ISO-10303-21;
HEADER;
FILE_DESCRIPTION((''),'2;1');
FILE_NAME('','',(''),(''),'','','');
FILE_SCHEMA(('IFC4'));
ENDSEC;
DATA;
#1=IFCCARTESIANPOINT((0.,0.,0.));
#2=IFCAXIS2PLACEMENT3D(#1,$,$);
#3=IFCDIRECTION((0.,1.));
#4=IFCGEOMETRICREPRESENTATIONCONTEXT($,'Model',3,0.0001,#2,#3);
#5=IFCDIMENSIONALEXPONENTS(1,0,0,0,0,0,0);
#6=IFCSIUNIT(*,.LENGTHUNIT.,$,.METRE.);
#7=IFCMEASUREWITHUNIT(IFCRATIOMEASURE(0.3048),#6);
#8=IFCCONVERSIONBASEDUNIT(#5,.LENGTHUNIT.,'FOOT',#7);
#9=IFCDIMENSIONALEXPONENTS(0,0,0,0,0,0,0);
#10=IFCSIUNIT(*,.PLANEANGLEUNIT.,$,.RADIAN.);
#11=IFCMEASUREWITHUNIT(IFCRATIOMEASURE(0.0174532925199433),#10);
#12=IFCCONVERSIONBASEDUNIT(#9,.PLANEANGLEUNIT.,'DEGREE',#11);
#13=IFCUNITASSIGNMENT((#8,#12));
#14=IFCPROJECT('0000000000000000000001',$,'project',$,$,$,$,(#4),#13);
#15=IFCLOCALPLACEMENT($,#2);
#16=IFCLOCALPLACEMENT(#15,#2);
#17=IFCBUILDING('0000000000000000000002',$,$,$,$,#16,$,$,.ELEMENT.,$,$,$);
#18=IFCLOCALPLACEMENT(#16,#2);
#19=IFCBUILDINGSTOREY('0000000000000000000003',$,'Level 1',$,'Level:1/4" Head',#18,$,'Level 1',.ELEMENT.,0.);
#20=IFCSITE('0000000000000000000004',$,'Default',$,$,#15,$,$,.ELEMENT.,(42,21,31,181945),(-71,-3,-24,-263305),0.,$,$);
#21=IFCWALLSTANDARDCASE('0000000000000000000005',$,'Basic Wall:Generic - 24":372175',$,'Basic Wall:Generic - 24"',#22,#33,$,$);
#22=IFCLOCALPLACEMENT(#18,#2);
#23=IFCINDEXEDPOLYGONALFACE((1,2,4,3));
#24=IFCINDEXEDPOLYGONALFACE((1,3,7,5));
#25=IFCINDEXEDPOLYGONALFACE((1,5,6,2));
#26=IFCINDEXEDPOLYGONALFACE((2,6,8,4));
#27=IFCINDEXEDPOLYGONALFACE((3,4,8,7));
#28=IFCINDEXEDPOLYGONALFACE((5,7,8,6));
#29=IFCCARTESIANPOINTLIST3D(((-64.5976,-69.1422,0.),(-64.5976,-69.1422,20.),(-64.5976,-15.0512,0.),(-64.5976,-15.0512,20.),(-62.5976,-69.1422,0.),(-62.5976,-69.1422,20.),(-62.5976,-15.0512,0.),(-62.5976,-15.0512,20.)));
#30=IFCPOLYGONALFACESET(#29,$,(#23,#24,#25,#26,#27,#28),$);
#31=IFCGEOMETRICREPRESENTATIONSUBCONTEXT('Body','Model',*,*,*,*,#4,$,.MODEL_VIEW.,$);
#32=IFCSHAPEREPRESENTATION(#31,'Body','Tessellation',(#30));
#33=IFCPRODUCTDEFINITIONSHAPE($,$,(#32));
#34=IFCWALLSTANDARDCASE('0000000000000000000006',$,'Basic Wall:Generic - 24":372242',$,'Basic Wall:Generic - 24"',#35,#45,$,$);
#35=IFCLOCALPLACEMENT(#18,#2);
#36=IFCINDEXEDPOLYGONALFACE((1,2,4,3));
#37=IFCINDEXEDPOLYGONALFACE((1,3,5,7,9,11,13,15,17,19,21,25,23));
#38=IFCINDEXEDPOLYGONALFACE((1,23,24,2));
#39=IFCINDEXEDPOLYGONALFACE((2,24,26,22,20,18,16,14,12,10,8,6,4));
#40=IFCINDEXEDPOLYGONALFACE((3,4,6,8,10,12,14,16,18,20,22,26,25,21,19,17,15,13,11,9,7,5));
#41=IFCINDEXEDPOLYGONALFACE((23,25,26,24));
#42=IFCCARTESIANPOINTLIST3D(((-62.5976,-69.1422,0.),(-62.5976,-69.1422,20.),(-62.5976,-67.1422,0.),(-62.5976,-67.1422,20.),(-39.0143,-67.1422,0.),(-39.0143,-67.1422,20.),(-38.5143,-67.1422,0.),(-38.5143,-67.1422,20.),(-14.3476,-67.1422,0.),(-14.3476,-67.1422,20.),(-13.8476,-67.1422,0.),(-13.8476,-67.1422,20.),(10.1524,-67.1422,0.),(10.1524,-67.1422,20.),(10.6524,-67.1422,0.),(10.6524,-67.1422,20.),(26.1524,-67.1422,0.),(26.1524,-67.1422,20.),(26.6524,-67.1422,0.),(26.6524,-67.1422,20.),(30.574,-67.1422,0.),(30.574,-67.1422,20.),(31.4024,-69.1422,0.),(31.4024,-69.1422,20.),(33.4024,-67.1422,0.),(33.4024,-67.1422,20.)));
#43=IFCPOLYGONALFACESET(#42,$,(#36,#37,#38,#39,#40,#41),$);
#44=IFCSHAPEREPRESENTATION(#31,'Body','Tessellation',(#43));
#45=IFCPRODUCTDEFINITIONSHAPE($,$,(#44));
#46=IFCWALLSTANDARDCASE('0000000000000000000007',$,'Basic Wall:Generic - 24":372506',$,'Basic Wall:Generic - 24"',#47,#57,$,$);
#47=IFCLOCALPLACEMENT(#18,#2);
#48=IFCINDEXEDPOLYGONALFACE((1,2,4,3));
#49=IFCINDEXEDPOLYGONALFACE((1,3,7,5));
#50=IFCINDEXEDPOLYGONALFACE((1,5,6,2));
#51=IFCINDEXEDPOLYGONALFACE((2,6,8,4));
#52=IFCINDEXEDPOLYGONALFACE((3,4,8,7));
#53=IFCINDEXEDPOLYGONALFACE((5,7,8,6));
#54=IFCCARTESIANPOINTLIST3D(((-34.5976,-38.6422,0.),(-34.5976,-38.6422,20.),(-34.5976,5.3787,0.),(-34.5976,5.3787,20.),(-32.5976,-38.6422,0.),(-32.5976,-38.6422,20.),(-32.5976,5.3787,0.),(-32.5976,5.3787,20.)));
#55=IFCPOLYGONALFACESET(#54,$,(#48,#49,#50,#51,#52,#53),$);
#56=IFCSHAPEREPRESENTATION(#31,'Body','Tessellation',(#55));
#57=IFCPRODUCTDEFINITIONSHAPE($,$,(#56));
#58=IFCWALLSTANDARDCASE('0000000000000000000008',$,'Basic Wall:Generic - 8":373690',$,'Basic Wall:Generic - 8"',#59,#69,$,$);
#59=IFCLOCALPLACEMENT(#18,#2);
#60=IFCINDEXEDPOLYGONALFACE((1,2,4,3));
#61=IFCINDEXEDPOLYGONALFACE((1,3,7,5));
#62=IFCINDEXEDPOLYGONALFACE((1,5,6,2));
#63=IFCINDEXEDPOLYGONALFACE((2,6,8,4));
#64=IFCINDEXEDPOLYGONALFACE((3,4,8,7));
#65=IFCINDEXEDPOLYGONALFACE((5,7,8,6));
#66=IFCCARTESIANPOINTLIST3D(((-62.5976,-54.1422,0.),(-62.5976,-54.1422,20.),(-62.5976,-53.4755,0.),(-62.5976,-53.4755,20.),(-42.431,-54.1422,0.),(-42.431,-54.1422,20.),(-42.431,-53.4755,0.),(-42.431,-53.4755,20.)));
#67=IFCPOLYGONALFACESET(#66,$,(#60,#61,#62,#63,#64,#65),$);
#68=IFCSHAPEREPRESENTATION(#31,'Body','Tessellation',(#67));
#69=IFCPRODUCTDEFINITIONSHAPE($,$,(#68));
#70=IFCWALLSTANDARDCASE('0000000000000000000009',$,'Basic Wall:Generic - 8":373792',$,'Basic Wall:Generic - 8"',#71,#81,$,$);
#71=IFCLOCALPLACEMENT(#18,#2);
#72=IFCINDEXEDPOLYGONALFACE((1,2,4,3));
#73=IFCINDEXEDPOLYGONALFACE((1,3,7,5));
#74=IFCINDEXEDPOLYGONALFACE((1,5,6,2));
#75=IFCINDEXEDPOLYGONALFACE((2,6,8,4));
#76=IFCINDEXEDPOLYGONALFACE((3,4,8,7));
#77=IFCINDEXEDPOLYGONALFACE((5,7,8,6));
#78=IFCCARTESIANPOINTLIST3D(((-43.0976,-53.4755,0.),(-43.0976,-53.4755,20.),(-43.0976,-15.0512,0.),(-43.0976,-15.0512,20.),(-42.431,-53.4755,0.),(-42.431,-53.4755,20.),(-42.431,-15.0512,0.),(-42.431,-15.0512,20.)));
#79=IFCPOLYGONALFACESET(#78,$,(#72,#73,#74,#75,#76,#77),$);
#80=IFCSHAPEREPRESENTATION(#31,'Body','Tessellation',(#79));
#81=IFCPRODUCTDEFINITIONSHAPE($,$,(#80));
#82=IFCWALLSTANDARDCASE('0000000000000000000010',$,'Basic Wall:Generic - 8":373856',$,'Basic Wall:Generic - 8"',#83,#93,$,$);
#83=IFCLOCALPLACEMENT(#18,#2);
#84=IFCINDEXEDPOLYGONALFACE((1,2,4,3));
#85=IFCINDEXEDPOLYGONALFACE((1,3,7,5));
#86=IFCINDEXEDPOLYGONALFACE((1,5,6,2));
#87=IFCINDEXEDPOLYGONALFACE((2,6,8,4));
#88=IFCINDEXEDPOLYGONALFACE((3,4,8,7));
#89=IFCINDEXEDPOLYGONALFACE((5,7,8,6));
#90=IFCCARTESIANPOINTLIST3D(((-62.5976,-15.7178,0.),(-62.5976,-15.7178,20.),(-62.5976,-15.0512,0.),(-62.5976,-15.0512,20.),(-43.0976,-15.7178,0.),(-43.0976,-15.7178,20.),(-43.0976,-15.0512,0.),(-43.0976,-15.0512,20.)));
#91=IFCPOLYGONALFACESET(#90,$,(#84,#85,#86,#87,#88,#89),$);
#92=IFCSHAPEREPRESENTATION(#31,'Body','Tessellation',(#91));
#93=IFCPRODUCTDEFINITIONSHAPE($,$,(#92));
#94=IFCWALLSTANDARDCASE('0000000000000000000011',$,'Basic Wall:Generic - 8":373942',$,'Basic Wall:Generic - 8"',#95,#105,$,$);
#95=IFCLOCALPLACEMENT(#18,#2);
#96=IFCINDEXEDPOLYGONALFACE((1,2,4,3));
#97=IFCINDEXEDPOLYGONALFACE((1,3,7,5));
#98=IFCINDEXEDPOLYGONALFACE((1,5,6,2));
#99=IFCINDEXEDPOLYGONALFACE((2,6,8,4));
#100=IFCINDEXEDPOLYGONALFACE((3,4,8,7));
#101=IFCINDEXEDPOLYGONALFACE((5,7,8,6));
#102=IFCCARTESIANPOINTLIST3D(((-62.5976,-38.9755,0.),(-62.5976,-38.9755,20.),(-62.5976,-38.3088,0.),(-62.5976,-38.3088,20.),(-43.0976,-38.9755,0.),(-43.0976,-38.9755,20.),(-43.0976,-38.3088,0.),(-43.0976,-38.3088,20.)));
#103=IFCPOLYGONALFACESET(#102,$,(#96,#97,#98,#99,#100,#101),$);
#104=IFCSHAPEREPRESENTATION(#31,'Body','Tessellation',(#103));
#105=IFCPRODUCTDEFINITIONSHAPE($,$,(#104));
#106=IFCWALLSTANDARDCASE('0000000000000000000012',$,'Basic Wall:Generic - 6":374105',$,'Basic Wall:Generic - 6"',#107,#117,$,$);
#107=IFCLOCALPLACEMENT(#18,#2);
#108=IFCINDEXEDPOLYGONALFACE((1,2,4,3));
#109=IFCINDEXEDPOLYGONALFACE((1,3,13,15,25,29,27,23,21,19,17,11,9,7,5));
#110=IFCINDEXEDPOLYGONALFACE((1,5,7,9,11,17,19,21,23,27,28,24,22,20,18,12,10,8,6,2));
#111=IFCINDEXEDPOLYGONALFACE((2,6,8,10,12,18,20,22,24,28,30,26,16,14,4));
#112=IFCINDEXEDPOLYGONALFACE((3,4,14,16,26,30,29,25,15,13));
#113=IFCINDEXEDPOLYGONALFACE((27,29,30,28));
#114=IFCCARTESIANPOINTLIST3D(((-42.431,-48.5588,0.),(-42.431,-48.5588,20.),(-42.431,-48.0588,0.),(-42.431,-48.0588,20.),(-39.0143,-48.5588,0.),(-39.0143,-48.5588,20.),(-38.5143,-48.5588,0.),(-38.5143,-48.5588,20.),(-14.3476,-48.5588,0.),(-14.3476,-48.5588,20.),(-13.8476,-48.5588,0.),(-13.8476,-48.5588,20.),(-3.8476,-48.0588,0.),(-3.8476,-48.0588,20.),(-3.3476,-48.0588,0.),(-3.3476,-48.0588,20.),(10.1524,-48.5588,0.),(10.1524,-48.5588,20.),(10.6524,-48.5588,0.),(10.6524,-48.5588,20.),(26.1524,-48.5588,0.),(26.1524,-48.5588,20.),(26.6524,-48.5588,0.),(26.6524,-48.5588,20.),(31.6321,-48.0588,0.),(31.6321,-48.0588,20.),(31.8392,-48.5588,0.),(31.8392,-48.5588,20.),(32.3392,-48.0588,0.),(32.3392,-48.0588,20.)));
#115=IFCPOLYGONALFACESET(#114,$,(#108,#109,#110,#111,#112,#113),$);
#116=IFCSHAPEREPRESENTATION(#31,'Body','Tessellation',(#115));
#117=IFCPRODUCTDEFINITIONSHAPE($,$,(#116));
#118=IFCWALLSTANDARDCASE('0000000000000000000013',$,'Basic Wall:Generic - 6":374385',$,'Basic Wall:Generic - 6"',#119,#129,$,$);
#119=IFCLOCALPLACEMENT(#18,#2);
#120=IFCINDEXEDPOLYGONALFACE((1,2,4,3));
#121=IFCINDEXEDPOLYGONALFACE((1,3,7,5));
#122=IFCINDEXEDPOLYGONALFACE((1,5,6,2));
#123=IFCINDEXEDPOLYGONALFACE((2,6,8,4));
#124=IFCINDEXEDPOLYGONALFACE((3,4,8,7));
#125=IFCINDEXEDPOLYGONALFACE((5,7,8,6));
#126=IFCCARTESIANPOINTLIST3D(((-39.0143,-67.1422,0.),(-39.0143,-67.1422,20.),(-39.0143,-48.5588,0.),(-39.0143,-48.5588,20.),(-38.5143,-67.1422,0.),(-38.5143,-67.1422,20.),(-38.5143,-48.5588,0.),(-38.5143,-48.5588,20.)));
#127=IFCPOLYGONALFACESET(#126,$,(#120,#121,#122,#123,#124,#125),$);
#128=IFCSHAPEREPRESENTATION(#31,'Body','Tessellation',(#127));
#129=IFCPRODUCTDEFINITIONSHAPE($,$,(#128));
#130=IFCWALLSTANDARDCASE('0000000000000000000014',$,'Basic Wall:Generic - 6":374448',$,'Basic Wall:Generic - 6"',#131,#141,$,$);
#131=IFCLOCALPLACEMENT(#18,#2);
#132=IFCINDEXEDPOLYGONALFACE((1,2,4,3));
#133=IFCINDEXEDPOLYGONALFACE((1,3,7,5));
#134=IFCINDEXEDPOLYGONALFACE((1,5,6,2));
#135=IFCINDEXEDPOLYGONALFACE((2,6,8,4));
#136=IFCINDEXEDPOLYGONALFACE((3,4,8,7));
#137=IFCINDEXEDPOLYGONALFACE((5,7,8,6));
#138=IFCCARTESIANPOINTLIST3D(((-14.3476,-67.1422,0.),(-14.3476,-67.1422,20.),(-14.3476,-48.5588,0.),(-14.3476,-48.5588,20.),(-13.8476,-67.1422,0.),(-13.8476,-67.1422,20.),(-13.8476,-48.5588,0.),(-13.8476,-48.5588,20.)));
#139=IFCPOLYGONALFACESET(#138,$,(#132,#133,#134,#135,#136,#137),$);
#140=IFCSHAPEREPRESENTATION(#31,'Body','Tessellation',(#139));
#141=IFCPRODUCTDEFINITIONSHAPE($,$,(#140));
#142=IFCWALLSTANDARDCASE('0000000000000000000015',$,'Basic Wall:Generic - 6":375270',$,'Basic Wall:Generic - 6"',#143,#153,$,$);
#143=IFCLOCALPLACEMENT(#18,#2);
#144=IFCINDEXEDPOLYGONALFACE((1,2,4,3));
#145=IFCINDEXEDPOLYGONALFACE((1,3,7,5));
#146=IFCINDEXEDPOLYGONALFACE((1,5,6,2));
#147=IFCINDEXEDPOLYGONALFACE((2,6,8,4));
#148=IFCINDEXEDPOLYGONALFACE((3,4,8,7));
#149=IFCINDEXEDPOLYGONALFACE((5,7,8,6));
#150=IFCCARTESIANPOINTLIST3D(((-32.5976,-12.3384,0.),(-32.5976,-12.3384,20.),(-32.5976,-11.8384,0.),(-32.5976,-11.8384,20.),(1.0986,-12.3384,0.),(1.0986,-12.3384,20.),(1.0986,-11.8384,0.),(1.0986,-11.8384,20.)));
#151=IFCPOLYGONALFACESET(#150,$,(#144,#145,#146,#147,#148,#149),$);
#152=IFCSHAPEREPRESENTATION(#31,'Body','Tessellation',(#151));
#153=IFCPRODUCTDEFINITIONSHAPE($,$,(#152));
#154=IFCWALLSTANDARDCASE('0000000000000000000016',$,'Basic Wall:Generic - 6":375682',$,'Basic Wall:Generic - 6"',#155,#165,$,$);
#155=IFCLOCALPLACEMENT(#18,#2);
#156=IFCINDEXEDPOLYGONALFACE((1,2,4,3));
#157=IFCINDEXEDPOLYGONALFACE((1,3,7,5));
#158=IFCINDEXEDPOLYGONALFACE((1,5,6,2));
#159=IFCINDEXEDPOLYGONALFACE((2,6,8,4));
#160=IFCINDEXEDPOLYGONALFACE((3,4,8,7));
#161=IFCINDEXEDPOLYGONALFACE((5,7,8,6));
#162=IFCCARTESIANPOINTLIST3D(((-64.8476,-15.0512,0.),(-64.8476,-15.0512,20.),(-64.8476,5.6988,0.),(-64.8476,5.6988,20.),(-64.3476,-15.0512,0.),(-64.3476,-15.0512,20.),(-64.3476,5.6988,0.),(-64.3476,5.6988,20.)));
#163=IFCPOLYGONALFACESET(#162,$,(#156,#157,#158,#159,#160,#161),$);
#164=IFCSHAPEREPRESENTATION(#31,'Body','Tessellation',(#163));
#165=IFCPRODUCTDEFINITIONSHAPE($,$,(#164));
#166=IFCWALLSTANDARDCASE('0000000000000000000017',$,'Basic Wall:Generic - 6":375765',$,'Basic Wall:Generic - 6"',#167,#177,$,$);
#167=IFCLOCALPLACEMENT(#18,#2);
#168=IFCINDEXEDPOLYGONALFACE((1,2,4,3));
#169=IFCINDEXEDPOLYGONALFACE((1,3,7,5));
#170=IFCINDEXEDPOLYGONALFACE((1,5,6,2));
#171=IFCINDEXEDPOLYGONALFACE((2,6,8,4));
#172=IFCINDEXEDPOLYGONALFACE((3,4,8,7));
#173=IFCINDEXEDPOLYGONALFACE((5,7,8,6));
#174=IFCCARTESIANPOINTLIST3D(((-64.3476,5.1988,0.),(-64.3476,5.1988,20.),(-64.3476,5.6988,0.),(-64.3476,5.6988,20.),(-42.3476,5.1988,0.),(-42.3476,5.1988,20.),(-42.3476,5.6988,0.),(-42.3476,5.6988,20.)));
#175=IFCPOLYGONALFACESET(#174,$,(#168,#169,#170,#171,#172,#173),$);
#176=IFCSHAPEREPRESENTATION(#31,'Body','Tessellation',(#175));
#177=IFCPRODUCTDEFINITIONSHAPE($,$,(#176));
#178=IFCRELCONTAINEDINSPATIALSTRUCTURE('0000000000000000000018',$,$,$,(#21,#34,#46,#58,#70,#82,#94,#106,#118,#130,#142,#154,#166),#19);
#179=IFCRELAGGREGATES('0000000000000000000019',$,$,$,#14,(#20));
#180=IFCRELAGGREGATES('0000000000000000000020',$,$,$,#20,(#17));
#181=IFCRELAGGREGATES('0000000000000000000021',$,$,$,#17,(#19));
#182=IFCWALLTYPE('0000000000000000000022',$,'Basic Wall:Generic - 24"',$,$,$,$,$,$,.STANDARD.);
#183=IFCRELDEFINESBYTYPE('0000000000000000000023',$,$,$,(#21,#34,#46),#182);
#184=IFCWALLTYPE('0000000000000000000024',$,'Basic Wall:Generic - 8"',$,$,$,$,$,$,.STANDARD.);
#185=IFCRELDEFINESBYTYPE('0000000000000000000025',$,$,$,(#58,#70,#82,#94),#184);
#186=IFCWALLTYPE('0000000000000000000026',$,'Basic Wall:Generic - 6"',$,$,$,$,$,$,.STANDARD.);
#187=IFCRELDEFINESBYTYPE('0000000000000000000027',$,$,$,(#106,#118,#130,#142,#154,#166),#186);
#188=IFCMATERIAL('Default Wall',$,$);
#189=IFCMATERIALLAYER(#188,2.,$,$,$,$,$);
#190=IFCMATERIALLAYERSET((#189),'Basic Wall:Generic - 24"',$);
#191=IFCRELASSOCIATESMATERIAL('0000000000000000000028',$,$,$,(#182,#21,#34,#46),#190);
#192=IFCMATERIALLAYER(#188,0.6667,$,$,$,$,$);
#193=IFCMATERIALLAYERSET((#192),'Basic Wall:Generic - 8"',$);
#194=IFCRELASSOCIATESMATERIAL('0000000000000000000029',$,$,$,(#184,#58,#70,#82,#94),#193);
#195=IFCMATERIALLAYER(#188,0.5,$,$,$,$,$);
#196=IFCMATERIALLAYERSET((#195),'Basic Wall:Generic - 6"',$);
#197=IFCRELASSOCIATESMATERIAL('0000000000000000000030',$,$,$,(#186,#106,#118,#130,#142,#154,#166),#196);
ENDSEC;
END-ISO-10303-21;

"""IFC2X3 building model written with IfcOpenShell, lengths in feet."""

from ifc_helpers import new_model, entity, si_unit, converted_unit, direction, frame, frame_2d, origin, place, context, subcontext, project, spatial, polyline, rectangle, outline, extrude, material, layer, layer_set, layer_usage, type_object, element, save


model = new_model("IFC2X3")

# Units and contexts
model_context = context("Model", 3, precision=0.0001, world=origin(), true_north=direction((0.0, 1.0)))
body_context = subcontext(model_context, "Body", "Model", "MODEL_VIEW")
ifc_project = project(units=[converted_unit("LENGTHUNIT", "FOOT", entity("IfcRatioMeasure", 0.3048), si_unit("LENGTHUNIT", "METRE"), dimensions=[1, 0, 0, 0, 0, 0, 0]), converted_unit("PLANEANGLEUNIT", "DEGREE", entity("IfcRatioMeasure", 0.0174532925199433), si_unit("PLANEANGLEUNIT", "RADIAN"), dimensions=[0, 0, 0, 0, 0, 0, 0])], contexts=[model_context])

# Site, building, storey
site_placement = place(None, origin())
site = spatial("IfcSite", under=ifc_project, at=site_placement, Name="Default", CompositionType="ELEMENT", RefLatitude=(42, 21, 31, 181945), RefLongitude=(-71, -3, -24, -263305), RefElevation=0.0)
building_placement = place(site_placement, origin())
building = spatial("IfcBuilding", under=site, at=building_placement, CompositionType="ELEMENT")
storey_placement = place(building_placement, origin())
storey = spatial("IfcBuildingStorey", under=building, at=storey_placement, Name="Level 1", ObjectType="Level:1/4\" Head", LongName="Level 1", CompositionType="ELEMENT", Elevation=0.0)

# Walls
ifc_material = material(Name="Default Wall")
ifc_layer_1 = layer(ifc_material, 2.0)
ifc_layer_set_1 = layer_set([ifc_layer_1], Name="Basic Wall:Generic - 24\"")
ifc_layer_usage_1 = layer_usage(ifc_layer_set_1, "AXIS2", "NEGATIVE", 1.0)
wall_type_1 = type_object("IfcWallType", Name="Basic Wall:Generic - 24\"", PredefinedType="STANDARD", material=ifc_layer_set_1)
wall_1_placement = place(storey_placement, frame((-63.5976, -15.0512, 0.0), z_axis=(0.0, 0.0, 1.0), x_axis=(0.0, -1.0, 0.0)))
element("IfcWallStandardCase", 1, at=wall_1_placement, inside=storey, type_object=wall_type_1, material=ifc_layer_usage_1, Name="Basic Wall:Generic - 24\":372175", ObjectType="Basic Wall:Generic - 24\"", context=body_context, shape_type="SweptSolid", body=[
    extrude(rectangle(XDim=54.091, YDim=2.0, at=frame_2d((27.0455, 0.0), x_axis=(-1.0, 0.0))), origin(), (0.0, 0.0, 1.0), 20.0),
])
ifc_layer_usage_2 = layer_usage(ifc_layer_set_1, "AXIS2", "NEGATIVE", 1.0)
wall_2_placement = place(storey_placement, frame((-62.5976, -68.1422, 0.0)))
element("IfcWallStandardCase", 2, at=wall_2_placement, inside=storey, type_object=wall_type_1, material=ifc_layer_usage_2, Name="Basic Wall:Generic - 24\":372242", ObjectType="Basic Wall:Generic - 24\"", context=body_context, shape_type="SweptSolid", body=[
    extrude(outline(polyline([(94.0, -1.0), (96.0, 1.0), (93.1716, 1.0), (89.25, 1.0), (88.75, 1.0), (73.25, 1.0), (72.75, 1.0), (48.75, 1.0), (48.25, 1.0), (24.0833, 1.0), (23.5833, 1.0), (0.0, 1.0), (0.0, -1.0), (94.0, -1.0)])), origin(), (0.0, 0.0, 1.0), 20.0),
])
ifc_layer_usage_3 = layer_usage(ifc_layer_set_1, "AXIS2", "NEGATIVE", 1.0)
wall_3_placement = place(storey_placement, frame((-33.5976, 5.3787, 0.0), z_axis=(0.0, 0.0, 1.0), x_axis=(0.0, -1.0, 0.0)))
element("IfcWallStandardCase", 3, at=wall_3_placement, inside=storey, type_object=wall_type_1, material=ifc_layer_usage_3, Name="Basic Wall:Generic - 24\":372506", ObjectType="Basic Wall:Generic - 24\"", context=body_context, shape_type="SweptSolid", body=[
    extrude(rectangle(XDim=44.0208, YDim=2.0, at=frame_2d((22.0104, 0.0), x_axis=(-1.0, 0.0))), origin(), (0.0, 0.0, 1.0), 20.0),
])
ifc_layer_2 = layer(ifc_material, 0.6667)
ifc_layer_set_2 = layer_set([ifc_layer_2], Name="Basic Wall:Generic - 8\"")
ifc_layer_usage_4 = layer_usage(ifc_layer_set_2, "AXIS2", "NEGATIVE", 0.3333)
wall_type_2 = type_object("IfcWallType", Name="Basic Wall:Generic - 8\"", PredefinedType="STANDARD", material=ifc_layer_set_2)
wall_4_placement = place(storey_placement, frame((-42.431, -53.8088, 0.0), z_axis=(0.0, 0.0, 1.0), x_axis=(-1.0, 0.0, 0.0)))
element("IfcWallStandardCase", 4, at=wall_4_placement, inside=storey, type_object=wall_type_2, material=ifc_layer_usage_4, Name="Basic Wall:Generic - 8\":373690", ObjectType="Basic Wall:Generic - 8\"", context=body_context, shape_type="SweptSolid", body=[
    extrude(rectangle(XDim=20.1667, YDim=0.6667, at=frame_2d((10.0833, 0.0), x_axis=(-1.0, 0.0))), origin(), (0.0, 0.0, 1.0), 20.0),
])
ifc_layer_usage_5 = layer_usage(ifc_layer_set_2, "AXIS2", "NEGATIVE", 0.3333)
wall_5_placement = place(storey_placement, frame((-42.7643, -53.4755, 0.0), z_axis=(0.0, 0.0, 1.0), x_axis=(0.0, 1.0, 0.0)))
element("IfcWallStandardCase", 5, at=wall_5_placement, inside=storey, type_object=wall_type_2, material=ifc_layer_usage_5, Name="Basic Wall:Generic - 8\":373792", ObjectType="Basic Wall:Generic - 8\"", context=body_context, shape_type="SweptSolid", body=[
    extrude(rectangle(XDim=38.4243, YDim=0.6667, at=frame_2d((19.2122, 0.0), x_axis=(-1.0, 0.0))), origin(), (0.0, 0.0, 1.0), 20.0),
])
ifc_layer_usage_6 = layer_usage(ifc_layer_set_2, "AXIS2", "NEGATIVE", 0.3333)
wall_6_placement = place(storey_placement, frame((-43.0976, -15.3845, 0.0), z_axis=(0.0, 0.0, 1.0), x_axis=(-1.0, 0.0, 0.0)))
element("IfcWallStandardCase", 6, at=wall_6_placement, inside=storey, type_object=wall_type_2, material=ifc_layer_usage_6, Name="Basic Wall:Generic - 8\":373856", ObjectType="Basic Wall:Generic - 8\"", context=body_context, shape_type="SweptSolid", body=[
    extrude(rectangle(XDim=19.5, YDim=0.6667, at=frame_2d((9.75, 0.0), x_axis=(-1.0, 0.0))), origin(), (0.0, 0.0, 1.0), 20.0),
])
ifc_layer_usage_7 = layer_usage(ifc_layer_set_2, "AXIS2", "NEGATIVE", 0.3333)
wall_7_placement = place(storey_placement, frame((-62.5976, -38.6422, 0.0)))
element("IfcWallStandardCase", 7, at=wall_7_placement, inside=storey, type_object=wall_type_2, material=ifc_layer_usage_7, Name="Basic Wall:Generic - 8\":373942", ObjectType="Basic Wall:Generic - 8\"", context=body_context, shape_type="SweptSolid", body=[
    extrude(rectangle(XDim=19.5, YDim=0.6667, at=frame_2d((9.75, 0.0), x_axis=(-1.0, 0.0))), origin(), (0.0, 0.0, 1.0), 20.0),
])
ifc_layer_3 = layer(ifc_material, 0.5)
ifc_layer_set_3 = layer_set([ifc_layer_3], Name="Basic Wall:Generic - 6\"")
ifc_layer_usage_8 = layer_usage(ifc_layer_set_3, "AXIS2", "NEGATIVE", 0.25)
wall_type_3 = type_object("IfcWallType", Name="Basic Wall:Generic - 6\"", PredefinedType="STANDARD", material=ifc_layer_set_3)
wall_8_placement = place(storey_placement, frame((-42.431, -48.3088, 0.0)))
element("IfcWallStandardCase", 8, at=wall_8_placement, inside=storey, type_object=wall_type_3, material=ifc_layer_usage_8, Name="Basic Wall:Generic - 6\":374105", ObjectType="Basic Wall:Generic - 6\"", context=body_context, shape_type="SweptSolid", body=[
    extrude(outline(polyline([(74.2702, -0.25), (74.7702, 0.25), (74.0631, 0.25), (39.0833, 0.25), (38.5833, 0.25), (0.0, 0.25), (0.0, -0.25), (3.4167, -0.25), (3.9167, -0.25), (28.0833, -0.25), (28.5833, -0.25), (52.5833, -0.25), (53.0833, -0.25), (68.5833, -0.25), (69.0833, -0.25), (74.2702, -0.25)])), origin(), (0.0, 0.0, 1.0), 20.0),
])
ifc_layer_usage_9 = layer_usage(ifc_layer_set_3, "AXIS2", "NEGATIVE", 0.25)
wall_9_placement = place(storey_placement, frame((-38.7643, -48.5588, 0.0), z_axis=(0.0, 0.0, 1.0), x_axis=(0.0, -1.0, 0.0)))
element("IfcWallStandardCase", 9, at=wall_9_placement, inside=storey, type_object=wall_type_3, material=ifc_layer_usage_9, Name="Basic Wall:Generic - 6\":374385", ObjectType="Basic Wall:Generic - 6\"", context=body_context, shape_type="SweptSolid", body=[
    extrude(rectangle(XDim=18.5833, YDim=0.5, at=frame_2d((9.2917, 0.0), x_axis=(-1.0, 0.0))), origin(), (0.0, 0.0, 1.0), 20.0),
])
ifc_layer_usage_10 = layer_usage(ifc_layer_set_3, "AXIS2", "NEGATIVE", 0.25)
wall_10_placement = place(storey_placement, frame((-14.0976, -67.1422, 0.0), z_axis=(0.0, 0.0, 1.0), x_axis=(0.0, 1.0, 0.0)))
element("IfcWallStandardCase", 10, at=wall_10_placement, inside=storey, type_object=wall_type_3, material=ifc_layer_usage_10, Name="Basic Wall:Generic - 6\":374448", ObjectType="Basic Wall:Generic - 6\"", context=body_context, shape_type="SweptSolid", body=[
    extrude(rectangle(XDim=18.5833, YDim=0.5, at=frame_2d((9.2917, 0.0), x_axis=(-1.0, 0.0))), origin(), (0.0, 0.0, 1.0), 20.0),
])
ifc_layer_usage_11 = layer_usage(ifc_layer_set_3, "AXIS2", "NEGATIVE", 0.25)
wall_11_placement = place(storey_placement, frame((-32.5976, -12.0884, 0.0)))
element("IfcWallStandardCase", 11, at=wall_11_placement, inside=storey, type_object=wall_type_3, material=ifc_layer_usage_11, Name="Basic Wall:Generic - 6\":375270", ObjectType="Basic Wall:Generic - 6\"", context=body_context, shape_type="SweptSolid", body=[
    extrude(rectangle(XDim=33.6962, YDim=0.5, at=frame_2d((16.8481, 0.0), x_axis=(-1.0, 0.0))), origin(), (0.0, 0.0, 1.0), 20.0),
])
ifc_layer_usage_12 = layer_usage(ifc_layer_set_3, "AXIS2", "NEGATIVE", 0.25)
wall_12_placement = place(storey_placement, frame((-64.5976, -15.0512, 0.0), z_axis=(0.0, 0.0, 1.0), x_axis=(0.0, 1.0, 0.0)))
element("IfcWallStandardCase", 12, at=wall_12_placement, inside=storey, type_object=wall_type_3, material=ifc_layer_usage_12, Name="Basic Wall:Generic - 6\":375682", ObjectType="Basic Wall:Generic - 6\"", context=body_context, shape_type="SweptSolid", body=[
    extrude(rectangle(XDim=20.75, YDim=0.5, at=frame_2d((10.375, 0.0), x_axis=(-1.0, 0.0))), origin(), (0.0, 0.0, 1.0), 20.0),
])
ifc_layer_usage_13 = layer_usage(ifc_layer_set_3, "AXIS2", "NEGATIVE", 0.25)
wall_13_placement = place(storey_placement, frame((-64.3476, 5.4488, 0.0)))
element("IfcWallStandardCase", 13, at=wall_13_placement, inside=storey, type_object=wall_type_3, material=ifc_layer_usage_13, Name="Basic Wall:Generic - 6\":375765", ObjectType="Basic Wall:Generic - 6\"", context=body_context, shape_type="SweptSolid", body=[
    extrude(rectangle(XDim=22.0, YDim=0.5, at=frame_2d((11.0, 0.0), x_axis=(-1.0, 0.0))), origin(), (0.0, 0.0, 1.0), 20.0),
])

save(model, "model.ifc")
